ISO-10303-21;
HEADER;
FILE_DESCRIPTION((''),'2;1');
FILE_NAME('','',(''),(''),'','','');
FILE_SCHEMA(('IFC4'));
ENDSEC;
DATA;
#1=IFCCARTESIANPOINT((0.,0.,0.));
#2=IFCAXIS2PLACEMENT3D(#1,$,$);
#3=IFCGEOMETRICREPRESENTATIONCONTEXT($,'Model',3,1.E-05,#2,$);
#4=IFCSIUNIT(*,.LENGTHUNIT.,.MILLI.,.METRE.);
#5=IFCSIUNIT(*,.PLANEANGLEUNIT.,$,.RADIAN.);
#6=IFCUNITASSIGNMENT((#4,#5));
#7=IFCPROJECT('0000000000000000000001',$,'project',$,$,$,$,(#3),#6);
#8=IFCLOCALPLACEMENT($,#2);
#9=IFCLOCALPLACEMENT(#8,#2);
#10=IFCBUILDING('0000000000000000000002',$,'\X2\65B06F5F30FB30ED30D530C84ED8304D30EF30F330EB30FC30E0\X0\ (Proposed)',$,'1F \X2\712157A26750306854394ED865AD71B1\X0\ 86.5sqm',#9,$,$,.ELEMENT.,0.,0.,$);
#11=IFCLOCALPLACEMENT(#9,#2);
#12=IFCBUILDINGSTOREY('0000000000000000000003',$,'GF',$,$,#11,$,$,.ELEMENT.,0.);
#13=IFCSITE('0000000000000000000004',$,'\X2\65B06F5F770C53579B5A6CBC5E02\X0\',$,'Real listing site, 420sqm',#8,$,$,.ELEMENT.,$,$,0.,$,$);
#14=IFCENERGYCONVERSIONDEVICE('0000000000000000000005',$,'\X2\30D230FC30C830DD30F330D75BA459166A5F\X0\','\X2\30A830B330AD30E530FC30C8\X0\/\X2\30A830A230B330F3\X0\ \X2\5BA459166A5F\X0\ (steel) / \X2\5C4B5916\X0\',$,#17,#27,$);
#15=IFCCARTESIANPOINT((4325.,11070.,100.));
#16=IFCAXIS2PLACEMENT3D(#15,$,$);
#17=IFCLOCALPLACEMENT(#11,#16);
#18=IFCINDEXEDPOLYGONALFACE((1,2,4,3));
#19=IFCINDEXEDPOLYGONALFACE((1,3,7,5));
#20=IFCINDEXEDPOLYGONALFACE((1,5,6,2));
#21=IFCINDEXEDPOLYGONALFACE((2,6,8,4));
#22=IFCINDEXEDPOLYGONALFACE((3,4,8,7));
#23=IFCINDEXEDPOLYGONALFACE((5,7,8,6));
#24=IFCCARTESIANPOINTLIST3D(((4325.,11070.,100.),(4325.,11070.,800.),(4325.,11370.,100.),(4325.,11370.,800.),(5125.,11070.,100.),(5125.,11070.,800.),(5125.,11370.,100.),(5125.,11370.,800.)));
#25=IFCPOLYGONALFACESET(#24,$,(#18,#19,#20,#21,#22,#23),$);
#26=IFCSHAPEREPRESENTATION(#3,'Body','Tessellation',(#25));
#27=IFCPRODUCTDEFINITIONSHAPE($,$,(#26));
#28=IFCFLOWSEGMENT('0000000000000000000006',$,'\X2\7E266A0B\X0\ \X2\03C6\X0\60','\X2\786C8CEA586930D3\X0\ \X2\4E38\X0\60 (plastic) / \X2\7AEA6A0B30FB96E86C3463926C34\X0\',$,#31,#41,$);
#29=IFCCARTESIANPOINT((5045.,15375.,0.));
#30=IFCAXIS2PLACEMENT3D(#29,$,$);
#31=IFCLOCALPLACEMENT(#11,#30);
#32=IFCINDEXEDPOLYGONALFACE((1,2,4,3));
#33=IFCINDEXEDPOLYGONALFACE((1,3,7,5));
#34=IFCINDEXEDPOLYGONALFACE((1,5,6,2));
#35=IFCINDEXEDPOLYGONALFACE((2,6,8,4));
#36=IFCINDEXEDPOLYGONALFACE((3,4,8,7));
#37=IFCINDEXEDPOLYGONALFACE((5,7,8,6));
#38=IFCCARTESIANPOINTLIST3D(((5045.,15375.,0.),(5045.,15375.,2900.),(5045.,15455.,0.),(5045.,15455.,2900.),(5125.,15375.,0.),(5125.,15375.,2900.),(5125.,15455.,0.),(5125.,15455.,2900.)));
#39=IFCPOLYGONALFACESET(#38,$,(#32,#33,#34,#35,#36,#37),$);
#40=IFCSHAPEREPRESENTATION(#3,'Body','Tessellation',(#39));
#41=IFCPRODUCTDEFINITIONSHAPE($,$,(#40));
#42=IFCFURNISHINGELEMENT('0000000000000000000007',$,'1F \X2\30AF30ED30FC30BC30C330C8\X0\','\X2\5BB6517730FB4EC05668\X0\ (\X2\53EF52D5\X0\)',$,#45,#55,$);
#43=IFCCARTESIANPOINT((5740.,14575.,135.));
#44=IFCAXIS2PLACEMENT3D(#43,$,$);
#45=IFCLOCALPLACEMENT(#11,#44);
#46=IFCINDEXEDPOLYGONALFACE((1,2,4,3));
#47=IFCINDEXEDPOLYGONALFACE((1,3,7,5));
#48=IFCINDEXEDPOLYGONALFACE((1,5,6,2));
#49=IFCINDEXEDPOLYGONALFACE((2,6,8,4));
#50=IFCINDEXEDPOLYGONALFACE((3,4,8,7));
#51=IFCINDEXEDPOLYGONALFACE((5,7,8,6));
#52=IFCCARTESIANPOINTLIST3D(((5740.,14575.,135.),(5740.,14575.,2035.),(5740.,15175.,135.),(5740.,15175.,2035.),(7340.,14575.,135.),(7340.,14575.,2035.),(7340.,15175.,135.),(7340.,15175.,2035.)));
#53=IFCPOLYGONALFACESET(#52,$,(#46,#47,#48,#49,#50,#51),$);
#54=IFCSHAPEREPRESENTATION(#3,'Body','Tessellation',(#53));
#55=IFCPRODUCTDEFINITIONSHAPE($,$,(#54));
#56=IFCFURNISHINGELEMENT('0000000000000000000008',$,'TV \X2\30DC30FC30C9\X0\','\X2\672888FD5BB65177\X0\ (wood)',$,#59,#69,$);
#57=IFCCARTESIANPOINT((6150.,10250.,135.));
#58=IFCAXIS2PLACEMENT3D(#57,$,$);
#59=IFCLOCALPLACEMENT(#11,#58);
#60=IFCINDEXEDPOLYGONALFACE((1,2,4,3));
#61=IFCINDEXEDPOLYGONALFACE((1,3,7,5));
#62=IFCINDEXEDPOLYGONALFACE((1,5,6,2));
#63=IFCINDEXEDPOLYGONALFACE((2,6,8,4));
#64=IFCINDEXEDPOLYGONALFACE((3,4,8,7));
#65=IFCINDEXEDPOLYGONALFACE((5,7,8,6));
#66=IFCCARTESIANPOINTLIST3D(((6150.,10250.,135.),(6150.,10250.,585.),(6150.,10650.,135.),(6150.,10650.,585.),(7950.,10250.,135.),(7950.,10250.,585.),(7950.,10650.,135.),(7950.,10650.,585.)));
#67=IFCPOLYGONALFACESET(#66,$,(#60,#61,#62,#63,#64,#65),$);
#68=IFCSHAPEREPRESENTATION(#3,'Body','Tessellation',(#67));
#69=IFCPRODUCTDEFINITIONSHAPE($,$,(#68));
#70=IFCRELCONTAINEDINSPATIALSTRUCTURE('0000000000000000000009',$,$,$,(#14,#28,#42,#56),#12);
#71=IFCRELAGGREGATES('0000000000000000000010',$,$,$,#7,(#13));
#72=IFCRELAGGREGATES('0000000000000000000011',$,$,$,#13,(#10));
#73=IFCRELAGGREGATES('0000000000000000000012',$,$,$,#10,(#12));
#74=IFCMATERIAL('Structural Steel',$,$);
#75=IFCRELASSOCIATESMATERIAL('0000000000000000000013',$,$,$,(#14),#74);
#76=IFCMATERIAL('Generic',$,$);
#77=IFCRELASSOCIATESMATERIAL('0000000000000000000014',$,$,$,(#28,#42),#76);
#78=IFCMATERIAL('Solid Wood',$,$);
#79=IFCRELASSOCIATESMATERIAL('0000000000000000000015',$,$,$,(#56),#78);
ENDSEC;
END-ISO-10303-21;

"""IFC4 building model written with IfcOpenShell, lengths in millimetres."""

from ifc_helpers import new_model, si_unit, frame, frame_2d, origin, place, context, project, spatial, rectangle, extrude, material, element, save


model = new_model("IFC4")

# Units and contexts
model_context = context("Model", 3, precision=1e-05, world=origin())
ifc_project = project(units=[si_unit("LENGTHUNIT", "METRE", prefix="MILLI"), si_unit("PLANEANGLEUNIT", "RADIAN")], contexts=[model_context])

# Site, building, storey
site_placement = place(None, origin())
site = spatial("IfcSite", under=ifc_project, at=site_placement, Name="新潟県南魚沼市", ObjectType="Real listing site, 420sqm", CompositionType="ELEMENT", RefElevation=0.0)
building_placement = place(site_placement, origin())
building = spatial("IfcBuilding", under=site, at=building_placement, Name="新潟・ロフト付きワンルーム (Proposed)", ObjectType="1F 無垢材と吹付断熱 86.5sqm", CompositionType="ELEMENT", ElevationOfRefHeight=0.0, ElevationOfTerrain=0.0)
storey_placement = place(building_placement, origin())
storey = spatial("IfcBuildingStorey", under=building, at=storey_placement, Name="GF", CompositionType="ELEMENT", Elevation=0.0)

# Shared definitions
ifc_material_1 = material(Name="Solid Wood")

# Shared definitions
ifc_material_2 = material(Name="Structural Steel")

# Shared definitions
ifc_material_3 = material(Name="Generic")

# Energy conversion device
energy_conversion_device_placement = place(storey_placement, frame((4325.0, 11070.0, 100.0)))
element("IfcEnergyConversionDevice", 1, at=energy_conversion_device_placement, inside=storey, material=ifc_material_2, Name="ヒートポンプ室外機", Description="エコキュート/エアコン 室外機 (steel) / 屋外", context=model_context, shape_type="SweptSolid", body=[
    extrude(rectangle(XDim=800.0, YDim=300.0, at=frame_2d((400.0, 150.0))), frame((4325.0, 11070.0, 100.0)), (0.0, 0.0, 1.0), 700.0),
])

# Flow segment
flow_segment_1_placement = place(storey_placement, frame((5045.0, 15375.0, 0.0)))
element("IfcFlowSegment", 2, at=flow_segment_1_placement, inside=storey, material=ifc_material_3, Name="縦樋 φ60", Description="硬質塩ビ 丸60 (plastic) / 竪樋・雨水排水", context=model_context, shape_type="SweptSolid", body=[
    extrude(rectangle(XDim=80.0, YDim=80.0, at=frame_2d((40.0, 40.0))), frame((5045.0, 15375.0, 0.0)), (0.0, 0.0, 1.0), 2900.0),
])

# Furnishing elements
furnishing_1_placement = place(storey_placement, frame((5740.0, 14575.0, 135.0)))
element("IfcFurnishingElement", 3, at=furnishing_1_placement, inside=storey, material=ifc_material_3, Name="1F クローゼット", Description="家具・什器 (可動)", context=model_context, shape_type="SweptSolid", body=[
    extrude(rectangle(XDim=1600.0, YDim=600.0, at=frame_2d((800.0, 300.0))), frame((5740.0, 14575.0, 135.0)), (0.0, 0.0, 1.0), 1900.0),
])
furnishing_2_placement = place(storey_placement, frame((6150.0, 10250.0, 135.0)))
element("IfcFurnishingElement", 4, at=furnishing_2_placement, inside=storey, material=ifc_material_1, Name="TV ボード", Description="木製家具 (wood)", context=model_context, shape_type="SweptSolid", body=[
    extrude(rectangle(XDim=1800.0, YDim=400.0, at=frame_2d((900.0, 200.0))), frame((6150.0, 10250.0, 135.0)), (0.0, 0.0, 1.0), 450.0),
])

save(model, "model.ifc")
